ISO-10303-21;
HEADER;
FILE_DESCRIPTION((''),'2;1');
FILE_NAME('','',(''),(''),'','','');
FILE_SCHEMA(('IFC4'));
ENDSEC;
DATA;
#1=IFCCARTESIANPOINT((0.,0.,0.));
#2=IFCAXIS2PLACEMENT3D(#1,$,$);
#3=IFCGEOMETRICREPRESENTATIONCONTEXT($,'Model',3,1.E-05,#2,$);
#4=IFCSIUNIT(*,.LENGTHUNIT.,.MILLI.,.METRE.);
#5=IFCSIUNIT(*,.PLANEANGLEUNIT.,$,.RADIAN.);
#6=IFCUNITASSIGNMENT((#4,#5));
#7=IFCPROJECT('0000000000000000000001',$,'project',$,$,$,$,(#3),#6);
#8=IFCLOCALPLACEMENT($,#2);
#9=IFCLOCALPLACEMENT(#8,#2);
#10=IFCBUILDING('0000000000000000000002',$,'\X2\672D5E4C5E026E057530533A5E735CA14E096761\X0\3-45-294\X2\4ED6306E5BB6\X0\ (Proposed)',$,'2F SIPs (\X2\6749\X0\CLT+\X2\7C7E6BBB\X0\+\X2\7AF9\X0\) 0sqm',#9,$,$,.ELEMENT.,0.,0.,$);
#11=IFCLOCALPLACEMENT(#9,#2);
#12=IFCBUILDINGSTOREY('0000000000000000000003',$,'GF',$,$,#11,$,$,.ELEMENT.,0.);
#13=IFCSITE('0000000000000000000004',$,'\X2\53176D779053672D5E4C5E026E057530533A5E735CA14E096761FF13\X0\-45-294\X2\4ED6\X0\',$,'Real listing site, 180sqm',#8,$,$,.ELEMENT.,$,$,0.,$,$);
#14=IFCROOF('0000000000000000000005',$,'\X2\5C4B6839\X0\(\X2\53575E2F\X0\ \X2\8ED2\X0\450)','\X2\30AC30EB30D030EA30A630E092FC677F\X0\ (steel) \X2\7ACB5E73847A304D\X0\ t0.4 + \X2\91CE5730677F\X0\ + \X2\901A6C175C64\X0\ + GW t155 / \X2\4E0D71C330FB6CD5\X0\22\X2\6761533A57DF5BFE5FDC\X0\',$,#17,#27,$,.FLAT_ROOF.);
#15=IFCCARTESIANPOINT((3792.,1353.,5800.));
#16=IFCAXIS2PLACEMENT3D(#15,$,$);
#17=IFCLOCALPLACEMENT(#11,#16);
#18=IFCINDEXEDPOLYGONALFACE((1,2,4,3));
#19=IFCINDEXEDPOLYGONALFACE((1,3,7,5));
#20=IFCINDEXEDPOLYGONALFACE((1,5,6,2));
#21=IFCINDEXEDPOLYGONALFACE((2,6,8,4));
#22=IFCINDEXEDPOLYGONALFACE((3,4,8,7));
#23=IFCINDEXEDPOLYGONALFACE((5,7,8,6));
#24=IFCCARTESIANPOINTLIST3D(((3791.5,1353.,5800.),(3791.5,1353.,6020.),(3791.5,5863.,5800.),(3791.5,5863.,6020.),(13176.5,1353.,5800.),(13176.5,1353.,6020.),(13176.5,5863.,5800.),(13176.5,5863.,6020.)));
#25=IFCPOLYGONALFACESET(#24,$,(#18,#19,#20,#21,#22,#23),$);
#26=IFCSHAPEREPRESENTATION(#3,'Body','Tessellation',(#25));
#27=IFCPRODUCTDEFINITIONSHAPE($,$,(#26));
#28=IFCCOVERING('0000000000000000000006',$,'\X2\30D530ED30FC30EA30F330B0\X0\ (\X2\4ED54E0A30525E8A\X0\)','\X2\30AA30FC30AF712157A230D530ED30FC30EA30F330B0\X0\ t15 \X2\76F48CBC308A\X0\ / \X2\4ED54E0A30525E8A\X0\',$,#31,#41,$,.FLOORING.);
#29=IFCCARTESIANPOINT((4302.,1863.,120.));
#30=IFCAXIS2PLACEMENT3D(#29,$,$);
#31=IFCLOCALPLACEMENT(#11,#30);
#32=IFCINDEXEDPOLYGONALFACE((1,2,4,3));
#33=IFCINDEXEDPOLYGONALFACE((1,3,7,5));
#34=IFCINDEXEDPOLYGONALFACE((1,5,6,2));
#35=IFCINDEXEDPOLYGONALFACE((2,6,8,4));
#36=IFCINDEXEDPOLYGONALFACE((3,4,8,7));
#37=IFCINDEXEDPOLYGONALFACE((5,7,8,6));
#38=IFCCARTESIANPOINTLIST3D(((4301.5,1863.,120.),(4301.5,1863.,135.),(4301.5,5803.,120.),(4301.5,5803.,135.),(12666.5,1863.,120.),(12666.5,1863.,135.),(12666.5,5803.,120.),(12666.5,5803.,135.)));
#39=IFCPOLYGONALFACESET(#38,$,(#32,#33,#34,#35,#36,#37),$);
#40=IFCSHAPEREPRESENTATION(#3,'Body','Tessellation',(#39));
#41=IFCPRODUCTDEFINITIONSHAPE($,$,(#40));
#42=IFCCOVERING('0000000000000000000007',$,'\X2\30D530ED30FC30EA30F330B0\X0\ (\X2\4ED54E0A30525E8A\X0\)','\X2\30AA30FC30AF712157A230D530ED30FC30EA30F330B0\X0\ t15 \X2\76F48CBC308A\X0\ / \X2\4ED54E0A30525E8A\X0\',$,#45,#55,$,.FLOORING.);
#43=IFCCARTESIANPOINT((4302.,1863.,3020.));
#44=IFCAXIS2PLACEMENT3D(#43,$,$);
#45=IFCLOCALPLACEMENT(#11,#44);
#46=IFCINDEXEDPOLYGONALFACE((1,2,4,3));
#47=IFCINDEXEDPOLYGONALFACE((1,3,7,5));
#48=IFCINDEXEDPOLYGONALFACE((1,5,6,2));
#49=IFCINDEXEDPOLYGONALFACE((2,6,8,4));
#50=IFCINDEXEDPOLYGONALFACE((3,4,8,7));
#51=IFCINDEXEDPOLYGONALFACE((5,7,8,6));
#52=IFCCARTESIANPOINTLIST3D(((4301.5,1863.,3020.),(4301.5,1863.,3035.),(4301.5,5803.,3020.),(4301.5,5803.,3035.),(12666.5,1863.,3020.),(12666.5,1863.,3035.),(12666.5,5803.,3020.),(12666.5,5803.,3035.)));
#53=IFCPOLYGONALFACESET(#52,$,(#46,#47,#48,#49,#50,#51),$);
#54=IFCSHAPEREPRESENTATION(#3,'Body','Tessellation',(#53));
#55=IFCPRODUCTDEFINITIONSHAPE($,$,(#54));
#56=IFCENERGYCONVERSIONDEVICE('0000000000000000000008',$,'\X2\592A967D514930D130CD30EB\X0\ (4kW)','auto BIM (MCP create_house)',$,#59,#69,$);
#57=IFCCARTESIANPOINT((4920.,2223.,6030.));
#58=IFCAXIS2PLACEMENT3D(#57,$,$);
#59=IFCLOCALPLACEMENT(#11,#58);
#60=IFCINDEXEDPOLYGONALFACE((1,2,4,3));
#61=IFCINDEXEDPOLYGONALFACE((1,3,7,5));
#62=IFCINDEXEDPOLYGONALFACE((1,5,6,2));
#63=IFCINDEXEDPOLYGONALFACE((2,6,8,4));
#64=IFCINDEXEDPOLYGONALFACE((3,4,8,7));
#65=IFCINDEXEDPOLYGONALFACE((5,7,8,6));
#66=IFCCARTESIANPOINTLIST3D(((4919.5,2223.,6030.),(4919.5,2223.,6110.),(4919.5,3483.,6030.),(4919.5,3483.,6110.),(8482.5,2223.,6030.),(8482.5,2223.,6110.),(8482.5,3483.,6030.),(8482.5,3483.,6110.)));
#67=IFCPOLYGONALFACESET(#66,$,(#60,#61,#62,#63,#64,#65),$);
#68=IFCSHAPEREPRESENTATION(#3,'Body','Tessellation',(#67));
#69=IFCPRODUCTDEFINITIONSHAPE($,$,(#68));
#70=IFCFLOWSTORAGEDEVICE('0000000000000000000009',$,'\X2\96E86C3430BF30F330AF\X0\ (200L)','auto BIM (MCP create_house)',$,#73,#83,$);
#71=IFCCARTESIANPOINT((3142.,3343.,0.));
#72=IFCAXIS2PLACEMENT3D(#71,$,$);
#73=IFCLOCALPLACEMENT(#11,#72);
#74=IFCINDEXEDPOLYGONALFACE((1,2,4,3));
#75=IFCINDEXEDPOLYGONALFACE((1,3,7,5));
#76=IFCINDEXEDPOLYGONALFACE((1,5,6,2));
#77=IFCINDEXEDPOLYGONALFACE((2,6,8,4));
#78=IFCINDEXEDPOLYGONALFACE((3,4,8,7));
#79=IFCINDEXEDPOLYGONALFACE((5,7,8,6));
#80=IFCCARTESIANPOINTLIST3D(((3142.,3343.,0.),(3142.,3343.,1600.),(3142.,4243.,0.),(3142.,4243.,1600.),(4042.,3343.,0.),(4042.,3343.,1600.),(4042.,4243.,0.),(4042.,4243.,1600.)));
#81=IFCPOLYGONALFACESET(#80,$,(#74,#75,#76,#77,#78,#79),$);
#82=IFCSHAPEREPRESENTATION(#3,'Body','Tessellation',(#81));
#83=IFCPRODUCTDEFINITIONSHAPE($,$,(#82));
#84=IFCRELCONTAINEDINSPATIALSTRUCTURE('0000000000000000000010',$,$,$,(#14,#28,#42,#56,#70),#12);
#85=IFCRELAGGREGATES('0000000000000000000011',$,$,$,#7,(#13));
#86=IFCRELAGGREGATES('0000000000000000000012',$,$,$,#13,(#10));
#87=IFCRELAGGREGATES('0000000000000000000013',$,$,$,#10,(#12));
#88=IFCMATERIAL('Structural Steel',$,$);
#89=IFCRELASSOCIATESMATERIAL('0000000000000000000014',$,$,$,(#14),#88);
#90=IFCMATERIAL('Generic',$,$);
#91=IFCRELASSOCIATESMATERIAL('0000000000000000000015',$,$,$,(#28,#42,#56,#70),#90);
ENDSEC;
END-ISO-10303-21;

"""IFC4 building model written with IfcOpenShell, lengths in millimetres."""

from ifc_helpers import new_model, si_unit, frame, frame_2d, origin, place, context, project, spatial, rectangle, extrude, material, element, save


model = new_model("IFC4")

# Units and contexts
model_context = context("Model", 3, precision=1e-05, world=origin())
ifc_project = project(units=[si_unit("LENGTHUNIT", "METRE", prefix="MILLI"), si_unit("PLANEANGLEUNIT", "RADIAN")], contexts=[model_context])

# Site, building, storey
site_placement = place(None, origin())
site = spatial("IfcSite", under=ifc_project, at=site_placement, Name="北海道札幌市清田区平岡三条３-45-294他", ObjectType="Real listing site, 180sqm", CompositionType="ELEMENT", RefElevation=0.0)
building_placement = place(site_placement, origin())
building = spatial("IfcBuilding", under=site, at=building_placement, Name="札幌市清田区平岡三条3-45-294他の家 (Proposed)", ObjectType="2F SIPs (杉CLT+籾殻+竹) 0sqm", CompositionType="ELEMENT", ElevationOfRefHeight=0.0, ElevationOfTerrain=0.0)
storey_placement = place(building_placement, origin())
storey = spatial("IfcBuildingStorey", under=building, at=storey_placement, Name="GF", CompositionType="ELEMENT", Elevation=0.0)

# Roof
ifc_material_1 = material(Name="Structural Steel")
for number, where, name in (
    (1, (3792.0, 1353.0, 5800.0), "屋根(南帯 軒450)"),
):
    element("IfcRoof", number, at=place(storey_placement, frame(where)), inside=storey, material=ifc_material_1, Name=name, Description="ガルバリウム鋼板 (steel) 立平葺き t0.4 + 野地板 + 通気層 + GW t155 / 不燃・法22条区域対応", PredefinedType="FLAT_ROOF", context=model_context, shape_type="SweptSolid", body=[
        extrude(rectangle(XDim=9385.0, YDim=4510.0, at=frame_2d((4692.0, 2255.0))), frame((3792.0, 1353.0, 5800.0)), (0.0, 0.0, 1.0), 220.0),
    ])

# Coverings
ifc_material_2 = material(Name="Generic")
covering_1_placement = place(storey_placement, frame((4302.0, 1863.0, 120.0)))
element("IfcCovering", 2, at=covering_1_placement, inside=storey, material=ifc_material_2, Name="フローリング (仕上げ床)", Description="オーク無垢フローリング t15 直貼り / 仕上げ床", PredefinedType="FLOORING", context=model_context, shape_type="SweptSolid", body=[
    extrude(rectangle(XDim=8365.0, YDim=3940.0, at=frame_2d((4182.0, 1970.0))), frame((4302.0, 1863.0, 120.0)), (0.0, 0.0, 1.0), 15.0),
])
covering_2_placement = place(storey_placement, frame((4302.0, 1863.0, 3020.0)))
element("IfcCovering", 3, at=covering_2_placement, inside=storey, material=ifc_material_2, Name="フローリング (仕上げ床)", Description="オーク無垢フローリング t15 直貼り / 仕上げ床", PredefinedType="FLOORING", context=model_context, shape_type="SweptSolid", body=[
    extrude(rectangle(XDim=8365.0, YDim=3940.0, at=frame_2d((4182.0, 1970.0))), frame((4302.0, 1863.0, 3020.0)), (0.0, 0.0, 1.0), 15.0),
])

# Energy conversion device
energy_conversion_device_placement = place(storey_placement, frame((4920.0, 2223.0, 6030.0)))
element("IfcEnergyConversionDevice", 4, at=energy_conversion_device_placement, inside=storey, material=ifc_material_2, Name="太陽光パネル (4kW)", Description="auto BIM (MCP create_house)", context=model_context, shape_type="SweptSolid", body=[
    extrude(rectangle(XDim=3563.0, YDim=1260.0, at=frame_2d((1781.0, 630.0))), frame((4920.0, 2223.0, 6030.0)), (0.0, 0.0, 1.0), 80.0),
])

# Flow storage device
flow_storage_device_placement = place(storey_placement, frame((3142.0, 3343.0, 0.0)))
element("IfcFlowStorageDevice", 5, at=flow_storage_device_placement, inside=storey, material=ifc_material_2, Name="雨水タンク (200L)", Description="auto BIM (MCP create_house)", context=model_context, shape_type="SweptSolid", body=[
    extrude(rectangle(XDim=900.0, YDim=900.0, at=frame_2d((450.0, 450.0))), frame((3142.0, 3343.0, 0.0)), (0.0, 0.0, 1.0), 1600.0),
])

save(model, "model.ifc")
